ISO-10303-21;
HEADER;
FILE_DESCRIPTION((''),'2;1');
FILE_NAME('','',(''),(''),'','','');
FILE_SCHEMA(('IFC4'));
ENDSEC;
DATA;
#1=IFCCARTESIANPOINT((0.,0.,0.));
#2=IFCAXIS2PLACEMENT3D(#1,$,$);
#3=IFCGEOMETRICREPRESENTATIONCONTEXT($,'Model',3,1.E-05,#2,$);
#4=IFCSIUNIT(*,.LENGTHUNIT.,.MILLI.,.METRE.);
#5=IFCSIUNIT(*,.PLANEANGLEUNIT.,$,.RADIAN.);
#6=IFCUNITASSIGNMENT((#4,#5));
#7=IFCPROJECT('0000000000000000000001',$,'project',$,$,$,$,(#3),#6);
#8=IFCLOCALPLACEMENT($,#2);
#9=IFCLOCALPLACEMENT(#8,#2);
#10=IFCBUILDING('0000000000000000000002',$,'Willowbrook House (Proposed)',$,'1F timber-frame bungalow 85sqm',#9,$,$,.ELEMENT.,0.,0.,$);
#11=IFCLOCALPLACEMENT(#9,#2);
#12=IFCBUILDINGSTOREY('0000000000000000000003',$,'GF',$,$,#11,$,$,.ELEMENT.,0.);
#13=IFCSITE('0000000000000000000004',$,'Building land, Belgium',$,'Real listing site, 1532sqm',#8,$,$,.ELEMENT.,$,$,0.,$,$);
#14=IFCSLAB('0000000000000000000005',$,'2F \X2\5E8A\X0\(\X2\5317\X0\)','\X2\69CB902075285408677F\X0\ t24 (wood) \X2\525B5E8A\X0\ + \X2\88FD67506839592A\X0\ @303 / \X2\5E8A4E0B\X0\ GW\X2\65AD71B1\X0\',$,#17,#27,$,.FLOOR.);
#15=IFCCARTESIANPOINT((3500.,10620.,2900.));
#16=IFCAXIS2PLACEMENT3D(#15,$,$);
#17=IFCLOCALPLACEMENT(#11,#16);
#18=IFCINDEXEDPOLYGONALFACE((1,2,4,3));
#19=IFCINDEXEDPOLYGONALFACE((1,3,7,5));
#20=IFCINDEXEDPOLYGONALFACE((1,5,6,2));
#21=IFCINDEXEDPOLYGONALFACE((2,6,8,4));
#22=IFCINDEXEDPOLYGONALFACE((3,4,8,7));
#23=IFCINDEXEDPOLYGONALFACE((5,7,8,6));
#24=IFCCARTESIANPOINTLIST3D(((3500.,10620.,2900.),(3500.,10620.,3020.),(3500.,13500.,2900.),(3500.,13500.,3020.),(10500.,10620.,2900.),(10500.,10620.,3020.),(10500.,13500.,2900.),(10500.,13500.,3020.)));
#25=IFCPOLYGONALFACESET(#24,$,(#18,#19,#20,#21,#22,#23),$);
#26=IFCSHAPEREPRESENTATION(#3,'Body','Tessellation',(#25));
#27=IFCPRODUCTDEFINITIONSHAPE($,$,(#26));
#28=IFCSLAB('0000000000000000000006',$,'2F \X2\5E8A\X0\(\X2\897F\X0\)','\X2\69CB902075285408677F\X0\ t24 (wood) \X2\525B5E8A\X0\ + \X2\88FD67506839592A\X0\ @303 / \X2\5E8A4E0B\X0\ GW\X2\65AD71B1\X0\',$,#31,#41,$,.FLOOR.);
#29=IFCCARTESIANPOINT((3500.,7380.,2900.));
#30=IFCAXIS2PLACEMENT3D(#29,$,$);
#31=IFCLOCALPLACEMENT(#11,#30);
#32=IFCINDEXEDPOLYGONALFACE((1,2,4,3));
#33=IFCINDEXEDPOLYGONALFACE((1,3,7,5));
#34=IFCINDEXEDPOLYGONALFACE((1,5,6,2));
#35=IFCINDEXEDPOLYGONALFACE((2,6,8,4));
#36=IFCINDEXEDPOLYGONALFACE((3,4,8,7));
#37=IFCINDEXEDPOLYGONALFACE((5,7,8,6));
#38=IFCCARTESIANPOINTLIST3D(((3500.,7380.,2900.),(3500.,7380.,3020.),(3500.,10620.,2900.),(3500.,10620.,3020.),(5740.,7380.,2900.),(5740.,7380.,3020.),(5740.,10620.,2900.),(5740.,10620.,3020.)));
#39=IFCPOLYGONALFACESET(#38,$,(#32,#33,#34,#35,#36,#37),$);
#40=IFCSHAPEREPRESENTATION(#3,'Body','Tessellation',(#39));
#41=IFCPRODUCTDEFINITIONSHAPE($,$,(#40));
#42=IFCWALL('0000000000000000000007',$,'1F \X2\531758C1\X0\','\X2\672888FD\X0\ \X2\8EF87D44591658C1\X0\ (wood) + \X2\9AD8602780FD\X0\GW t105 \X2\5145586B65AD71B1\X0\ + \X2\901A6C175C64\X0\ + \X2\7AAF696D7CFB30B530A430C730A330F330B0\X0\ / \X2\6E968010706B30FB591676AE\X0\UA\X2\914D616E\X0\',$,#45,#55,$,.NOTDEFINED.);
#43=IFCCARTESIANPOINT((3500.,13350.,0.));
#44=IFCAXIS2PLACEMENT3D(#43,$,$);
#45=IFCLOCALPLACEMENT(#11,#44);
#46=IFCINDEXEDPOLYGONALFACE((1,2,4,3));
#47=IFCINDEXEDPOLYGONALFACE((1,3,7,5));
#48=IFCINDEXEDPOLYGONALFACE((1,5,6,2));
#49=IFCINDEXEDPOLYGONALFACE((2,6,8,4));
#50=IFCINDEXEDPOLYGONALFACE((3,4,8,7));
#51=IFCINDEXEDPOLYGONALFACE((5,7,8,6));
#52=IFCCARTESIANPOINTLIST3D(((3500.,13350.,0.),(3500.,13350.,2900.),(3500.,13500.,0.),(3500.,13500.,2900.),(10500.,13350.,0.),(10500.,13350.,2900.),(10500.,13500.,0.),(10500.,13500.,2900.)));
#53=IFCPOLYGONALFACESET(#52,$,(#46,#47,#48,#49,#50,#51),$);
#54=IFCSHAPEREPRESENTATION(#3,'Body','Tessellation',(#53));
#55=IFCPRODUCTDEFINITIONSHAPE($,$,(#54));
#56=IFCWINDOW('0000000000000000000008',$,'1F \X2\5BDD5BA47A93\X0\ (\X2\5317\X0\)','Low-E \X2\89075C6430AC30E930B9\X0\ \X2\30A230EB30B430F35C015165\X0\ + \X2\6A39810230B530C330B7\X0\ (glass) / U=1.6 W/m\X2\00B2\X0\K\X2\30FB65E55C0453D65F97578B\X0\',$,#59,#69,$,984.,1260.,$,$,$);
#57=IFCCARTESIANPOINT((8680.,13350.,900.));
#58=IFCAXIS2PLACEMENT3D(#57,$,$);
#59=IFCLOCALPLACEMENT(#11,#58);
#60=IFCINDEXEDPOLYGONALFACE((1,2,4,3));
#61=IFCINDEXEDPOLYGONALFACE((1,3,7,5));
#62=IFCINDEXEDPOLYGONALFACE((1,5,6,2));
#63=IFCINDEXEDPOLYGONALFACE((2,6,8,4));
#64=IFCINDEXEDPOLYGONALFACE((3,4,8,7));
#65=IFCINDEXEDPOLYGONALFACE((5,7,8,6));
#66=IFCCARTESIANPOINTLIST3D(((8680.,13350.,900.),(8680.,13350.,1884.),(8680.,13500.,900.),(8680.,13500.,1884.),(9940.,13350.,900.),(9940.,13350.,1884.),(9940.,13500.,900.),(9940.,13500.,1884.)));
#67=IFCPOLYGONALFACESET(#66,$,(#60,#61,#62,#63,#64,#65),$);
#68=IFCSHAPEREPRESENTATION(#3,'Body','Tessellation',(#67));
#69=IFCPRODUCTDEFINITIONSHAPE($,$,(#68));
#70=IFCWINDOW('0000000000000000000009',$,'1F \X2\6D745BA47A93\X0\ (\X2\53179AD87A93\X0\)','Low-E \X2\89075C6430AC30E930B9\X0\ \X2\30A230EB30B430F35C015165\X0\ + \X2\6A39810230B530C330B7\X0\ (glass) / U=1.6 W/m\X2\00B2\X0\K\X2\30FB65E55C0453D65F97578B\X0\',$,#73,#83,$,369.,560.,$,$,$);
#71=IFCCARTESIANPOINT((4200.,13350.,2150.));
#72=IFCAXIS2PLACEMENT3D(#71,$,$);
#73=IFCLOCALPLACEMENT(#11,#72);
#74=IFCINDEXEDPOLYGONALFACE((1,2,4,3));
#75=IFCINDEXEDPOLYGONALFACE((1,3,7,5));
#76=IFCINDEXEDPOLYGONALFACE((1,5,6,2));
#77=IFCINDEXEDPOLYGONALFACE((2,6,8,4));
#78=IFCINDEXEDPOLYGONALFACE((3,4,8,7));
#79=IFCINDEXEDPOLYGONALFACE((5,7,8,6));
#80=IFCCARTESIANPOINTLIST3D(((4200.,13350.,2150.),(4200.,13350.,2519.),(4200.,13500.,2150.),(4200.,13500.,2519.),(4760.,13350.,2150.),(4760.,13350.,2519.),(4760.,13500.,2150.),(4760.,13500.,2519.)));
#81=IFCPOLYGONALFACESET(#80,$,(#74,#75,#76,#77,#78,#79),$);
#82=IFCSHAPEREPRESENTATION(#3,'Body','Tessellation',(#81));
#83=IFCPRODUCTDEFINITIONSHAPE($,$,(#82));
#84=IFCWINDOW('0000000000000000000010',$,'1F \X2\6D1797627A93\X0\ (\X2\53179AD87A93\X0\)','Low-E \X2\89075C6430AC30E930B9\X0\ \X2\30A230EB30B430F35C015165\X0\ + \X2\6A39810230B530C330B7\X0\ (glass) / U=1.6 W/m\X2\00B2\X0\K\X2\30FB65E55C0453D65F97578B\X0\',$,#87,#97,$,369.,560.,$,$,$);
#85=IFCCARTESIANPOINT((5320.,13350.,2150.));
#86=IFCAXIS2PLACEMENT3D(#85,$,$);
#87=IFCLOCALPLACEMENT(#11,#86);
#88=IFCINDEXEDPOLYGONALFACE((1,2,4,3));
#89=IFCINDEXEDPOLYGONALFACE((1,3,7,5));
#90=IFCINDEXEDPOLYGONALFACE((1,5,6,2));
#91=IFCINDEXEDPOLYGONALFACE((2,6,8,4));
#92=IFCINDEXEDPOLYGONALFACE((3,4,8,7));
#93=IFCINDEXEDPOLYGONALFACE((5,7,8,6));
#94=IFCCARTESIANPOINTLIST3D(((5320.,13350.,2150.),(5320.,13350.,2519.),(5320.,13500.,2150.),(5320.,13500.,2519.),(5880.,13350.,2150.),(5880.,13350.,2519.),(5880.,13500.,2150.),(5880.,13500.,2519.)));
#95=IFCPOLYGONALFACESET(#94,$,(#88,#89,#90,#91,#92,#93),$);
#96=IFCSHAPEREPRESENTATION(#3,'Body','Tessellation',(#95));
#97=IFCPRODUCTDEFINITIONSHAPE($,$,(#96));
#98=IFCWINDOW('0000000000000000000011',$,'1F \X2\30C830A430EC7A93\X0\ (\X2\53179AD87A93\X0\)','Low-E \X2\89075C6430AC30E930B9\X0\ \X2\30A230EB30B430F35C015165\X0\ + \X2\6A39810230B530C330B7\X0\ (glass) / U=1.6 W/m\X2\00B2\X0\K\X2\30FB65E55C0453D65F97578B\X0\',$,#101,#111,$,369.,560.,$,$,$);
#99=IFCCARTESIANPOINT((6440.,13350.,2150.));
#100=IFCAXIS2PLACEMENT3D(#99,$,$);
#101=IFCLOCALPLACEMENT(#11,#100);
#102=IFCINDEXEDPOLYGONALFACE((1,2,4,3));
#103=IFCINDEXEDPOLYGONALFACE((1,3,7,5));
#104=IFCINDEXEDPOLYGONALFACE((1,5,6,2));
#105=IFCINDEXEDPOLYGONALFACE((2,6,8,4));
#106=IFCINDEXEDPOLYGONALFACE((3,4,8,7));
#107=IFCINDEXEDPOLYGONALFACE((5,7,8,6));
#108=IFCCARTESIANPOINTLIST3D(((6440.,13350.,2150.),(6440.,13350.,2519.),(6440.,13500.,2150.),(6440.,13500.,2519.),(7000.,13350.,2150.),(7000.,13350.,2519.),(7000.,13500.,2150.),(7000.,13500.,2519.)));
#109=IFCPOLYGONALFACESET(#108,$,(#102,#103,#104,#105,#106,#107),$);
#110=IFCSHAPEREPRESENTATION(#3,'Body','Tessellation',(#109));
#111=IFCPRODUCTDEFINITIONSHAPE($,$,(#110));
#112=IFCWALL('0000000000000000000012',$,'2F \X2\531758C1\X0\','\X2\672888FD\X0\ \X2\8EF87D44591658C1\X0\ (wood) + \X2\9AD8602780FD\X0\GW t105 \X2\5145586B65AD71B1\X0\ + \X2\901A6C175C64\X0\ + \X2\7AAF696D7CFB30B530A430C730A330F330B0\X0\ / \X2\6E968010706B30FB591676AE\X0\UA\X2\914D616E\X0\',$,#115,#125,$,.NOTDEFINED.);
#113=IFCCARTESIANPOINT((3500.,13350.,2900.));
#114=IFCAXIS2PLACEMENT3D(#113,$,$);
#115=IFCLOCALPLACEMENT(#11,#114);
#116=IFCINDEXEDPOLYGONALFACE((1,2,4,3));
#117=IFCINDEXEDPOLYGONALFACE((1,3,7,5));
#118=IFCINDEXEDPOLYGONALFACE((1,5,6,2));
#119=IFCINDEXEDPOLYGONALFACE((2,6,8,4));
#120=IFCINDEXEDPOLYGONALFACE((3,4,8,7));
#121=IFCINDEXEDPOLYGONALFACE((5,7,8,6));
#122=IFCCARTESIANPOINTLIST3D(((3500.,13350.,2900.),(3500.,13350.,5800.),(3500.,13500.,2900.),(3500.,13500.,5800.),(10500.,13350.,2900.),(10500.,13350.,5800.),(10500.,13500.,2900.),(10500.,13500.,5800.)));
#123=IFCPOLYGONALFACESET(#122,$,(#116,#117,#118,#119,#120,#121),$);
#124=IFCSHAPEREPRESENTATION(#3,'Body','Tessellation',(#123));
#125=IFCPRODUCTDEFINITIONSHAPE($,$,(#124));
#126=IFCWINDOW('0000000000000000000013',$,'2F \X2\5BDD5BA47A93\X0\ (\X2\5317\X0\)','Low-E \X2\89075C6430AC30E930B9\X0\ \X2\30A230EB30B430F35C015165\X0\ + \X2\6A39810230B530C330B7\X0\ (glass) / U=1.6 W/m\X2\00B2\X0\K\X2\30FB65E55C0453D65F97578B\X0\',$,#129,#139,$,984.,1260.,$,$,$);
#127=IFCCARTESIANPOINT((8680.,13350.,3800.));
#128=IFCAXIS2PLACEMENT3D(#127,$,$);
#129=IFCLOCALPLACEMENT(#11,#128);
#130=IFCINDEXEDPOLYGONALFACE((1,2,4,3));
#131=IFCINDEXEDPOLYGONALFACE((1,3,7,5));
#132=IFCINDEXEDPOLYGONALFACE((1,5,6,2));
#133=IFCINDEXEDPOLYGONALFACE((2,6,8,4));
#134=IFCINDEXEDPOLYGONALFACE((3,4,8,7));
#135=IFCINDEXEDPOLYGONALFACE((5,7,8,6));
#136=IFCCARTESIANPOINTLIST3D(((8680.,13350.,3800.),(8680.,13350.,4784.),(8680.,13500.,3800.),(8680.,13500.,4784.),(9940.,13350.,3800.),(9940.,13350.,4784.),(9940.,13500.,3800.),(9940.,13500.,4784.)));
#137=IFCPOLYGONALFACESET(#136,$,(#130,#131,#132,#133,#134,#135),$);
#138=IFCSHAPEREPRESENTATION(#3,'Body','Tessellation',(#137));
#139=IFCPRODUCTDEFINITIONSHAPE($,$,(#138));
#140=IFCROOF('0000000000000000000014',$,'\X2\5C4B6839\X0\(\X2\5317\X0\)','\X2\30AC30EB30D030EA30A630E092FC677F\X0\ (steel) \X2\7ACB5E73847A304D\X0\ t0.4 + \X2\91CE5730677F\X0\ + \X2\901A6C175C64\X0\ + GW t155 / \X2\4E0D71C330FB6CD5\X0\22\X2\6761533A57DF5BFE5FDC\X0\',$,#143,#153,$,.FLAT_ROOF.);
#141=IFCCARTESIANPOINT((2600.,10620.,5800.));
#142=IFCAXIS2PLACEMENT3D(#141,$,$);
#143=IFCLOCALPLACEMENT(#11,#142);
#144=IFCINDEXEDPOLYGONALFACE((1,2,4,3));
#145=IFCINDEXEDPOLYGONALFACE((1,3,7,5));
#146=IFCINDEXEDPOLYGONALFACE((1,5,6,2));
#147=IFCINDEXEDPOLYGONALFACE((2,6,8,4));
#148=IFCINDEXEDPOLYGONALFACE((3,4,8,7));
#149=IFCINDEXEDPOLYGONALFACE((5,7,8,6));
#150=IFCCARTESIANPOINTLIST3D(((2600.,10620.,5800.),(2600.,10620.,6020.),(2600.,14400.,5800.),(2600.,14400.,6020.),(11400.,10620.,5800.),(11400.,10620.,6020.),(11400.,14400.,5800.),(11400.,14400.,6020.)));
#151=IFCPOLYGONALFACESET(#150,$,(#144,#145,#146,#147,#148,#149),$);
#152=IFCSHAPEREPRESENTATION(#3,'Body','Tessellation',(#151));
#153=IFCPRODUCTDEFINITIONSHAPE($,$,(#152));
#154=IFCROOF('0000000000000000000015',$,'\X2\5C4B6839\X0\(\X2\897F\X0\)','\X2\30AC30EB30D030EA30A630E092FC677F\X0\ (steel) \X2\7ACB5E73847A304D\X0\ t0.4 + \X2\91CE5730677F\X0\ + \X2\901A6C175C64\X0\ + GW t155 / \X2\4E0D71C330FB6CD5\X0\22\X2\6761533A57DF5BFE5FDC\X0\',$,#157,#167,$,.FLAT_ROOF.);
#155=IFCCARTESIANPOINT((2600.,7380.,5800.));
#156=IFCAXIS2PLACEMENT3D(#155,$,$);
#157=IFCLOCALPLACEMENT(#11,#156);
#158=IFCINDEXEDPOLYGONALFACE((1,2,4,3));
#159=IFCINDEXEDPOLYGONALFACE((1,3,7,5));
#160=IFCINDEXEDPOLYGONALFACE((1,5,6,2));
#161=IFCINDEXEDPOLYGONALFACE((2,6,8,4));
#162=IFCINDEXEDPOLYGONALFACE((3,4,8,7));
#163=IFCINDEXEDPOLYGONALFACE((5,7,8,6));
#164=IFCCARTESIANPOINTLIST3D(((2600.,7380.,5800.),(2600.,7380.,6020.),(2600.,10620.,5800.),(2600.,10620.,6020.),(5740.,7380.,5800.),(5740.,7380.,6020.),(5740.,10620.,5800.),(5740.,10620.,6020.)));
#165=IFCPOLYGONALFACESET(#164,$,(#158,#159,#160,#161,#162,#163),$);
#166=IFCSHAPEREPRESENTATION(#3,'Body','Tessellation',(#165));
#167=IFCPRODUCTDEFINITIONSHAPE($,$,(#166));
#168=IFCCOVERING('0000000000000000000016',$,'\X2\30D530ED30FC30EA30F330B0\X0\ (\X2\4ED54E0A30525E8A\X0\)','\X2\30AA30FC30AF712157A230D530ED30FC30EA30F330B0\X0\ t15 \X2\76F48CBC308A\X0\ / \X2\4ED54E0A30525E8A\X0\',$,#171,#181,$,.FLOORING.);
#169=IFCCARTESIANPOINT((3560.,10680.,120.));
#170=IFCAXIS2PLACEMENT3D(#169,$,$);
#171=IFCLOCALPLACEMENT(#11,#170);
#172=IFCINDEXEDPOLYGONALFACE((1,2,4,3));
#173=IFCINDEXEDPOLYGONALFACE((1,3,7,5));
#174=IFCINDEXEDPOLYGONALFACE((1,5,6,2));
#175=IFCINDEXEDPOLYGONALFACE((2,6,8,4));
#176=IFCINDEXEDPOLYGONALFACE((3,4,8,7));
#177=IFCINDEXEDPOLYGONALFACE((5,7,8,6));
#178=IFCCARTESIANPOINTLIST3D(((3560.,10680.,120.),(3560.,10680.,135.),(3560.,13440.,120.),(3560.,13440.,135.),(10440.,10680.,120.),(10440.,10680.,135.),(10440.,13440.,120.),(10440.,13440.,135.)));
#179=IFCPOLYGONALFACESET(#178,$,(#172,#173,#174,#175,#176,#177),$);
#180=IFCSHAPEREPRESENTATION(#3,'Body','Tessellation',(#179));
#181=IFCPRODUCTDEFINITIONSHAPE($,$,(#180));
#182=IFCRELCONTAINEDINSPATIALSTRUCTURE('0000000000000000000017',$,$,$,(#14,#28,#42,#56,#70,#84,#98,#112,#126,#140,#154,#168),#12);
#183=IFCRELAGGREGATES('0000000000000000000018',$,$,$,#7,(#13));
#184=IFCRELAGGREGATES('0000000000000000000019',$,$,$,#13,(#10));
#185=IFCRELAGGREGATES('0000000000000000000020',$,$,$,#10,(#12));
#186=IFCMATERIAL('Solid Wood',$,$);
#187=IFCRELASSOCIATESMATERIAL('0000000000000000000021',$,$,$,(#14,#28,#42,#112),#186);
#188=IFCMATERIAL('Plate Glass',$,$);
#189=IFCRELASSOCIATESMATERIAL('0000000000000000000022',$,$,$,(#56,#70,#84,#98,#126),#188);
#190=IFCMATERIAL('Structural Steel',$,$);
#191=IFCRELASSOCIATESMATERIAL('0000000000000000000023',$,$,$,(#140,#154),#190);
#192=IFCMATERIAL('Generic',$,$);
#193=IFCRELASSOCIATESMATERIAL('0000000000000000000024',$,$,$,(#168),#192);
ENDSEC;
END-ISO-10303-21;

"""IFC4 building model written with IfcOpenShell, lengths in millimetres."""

from ifc_helpers import new_model, si_unit, frame, frame_2d, origin, place, context, project, spatial, rectangle, extrude, material, element, fill, save


model = new_model("IFC4")

# Units and contexts
model_context = context("Model", 3, precision=1e-05, world=origin())
ifc_project = project(units=[si_unit("LENGTHUNIT", "METRE", prefix="MILLI"), si_unit("PLANEANGLEUNIT", "RADIAN")], contexts=[model_context])

# Site, building, storey
site_placement = place(None, origin())
site = spatial("IfcSite", under=ifc_project, at=site_placement, Name="Building land, Belgium", ObjectType="Real listing site, 1532sqm", CompositionType="ELEMENT", RefElevation=0.0)
building_placement = place(site_placement, origin())
building = spatial("IfcBuilding", under=site, at=building_placement, Name="Willowbrook House (Proposed)", ObjectType="1F timber-frame bungalow 85sqm", CompositionType="ELEMENT", ElevationOfRefHeight=0.0, ElevationOfTerrain=0.0)
storey_placement = place(building_placement, origin())
storey = spatial("IfcBuildingStorey", under=building, at=storey_placement, Name="GF", CompositionType="ELEMENT", Elevation=0.0)

# Slabs
ifc_material_1 = material(Name="Solid Wood")
slab_1_placement = place(storey_placement, frame((3500.0, 10620.0, 2900.0)))
element("IfcSlab", 1, at=slab_1_placement, inside=storey, material=ifc_material_1, Name="2F 床(北)", Description="構造用合板 t24 (wood) 剛床 + 製材根太 @303 / 床下 GW断熱", PredefinedType="FLOOR", context=model_context, shape_type="SweptSolid", body=[
    extrude(rectangle(XDim=7000.0, YDim=2880.0, at=frame_2d((3500.0, 1440.0))), frame((3500.0, 10620.0, 2900.0)), (0.0, 0.0, 1.0), 120.0),
])
slab_2_placement = place(storey_placement, frame((3500.0, 7380.0, 2900.0)))
element("IfcSlab", 2, at=slab_2_placement, inside=storey, material=ifc_material_1, Name="2F 床(西)", Description="構造用合板 t24 (wood) 剛床 + 製材根太 @303 / 床下 GW断熱", PredefinedType="FLOOR", context=model_context, shape_type="SweptSolid", body=[
    extrude(rectangle(XDim=2240.0, YDim=3240.0, at=frame_2d((1120.0, 1620.0))), frame((3500.0, 7380.0, 2900.0)), (0.0, 0.0, 1.0), 120.0),
])

# Wall, openings, windows
wall_1_placement = place(storey_placement, frame((3500.0, 13350.0, 0.0)))
wall_1 = element("IfcWall", 3, at=wall_1_placement, inside=storey, material=ifc_material_1, Name="1F 北壁", Description="木製 軸組外壁 (wood) + 高性能GW t105 充填断熱 + 通気層 + 窯業系サイディング / 準耐火・外皮UA配慮", PredefinedType="NOTDEFINED", context=model_context, shape_type="SweptSolid", body=[
    extrude(rectangle(XDim=7000.0, YDim=150.0, at=frame_2d((3500.0, 75.0))), frame((3500.0, 13350.0, 0.0)), (0.0, 0.0, 1.0), 2900.0),
])
opening_1_placement = place(storey_placement, frame((8680.0, 13350.0, 900.0)))
opening_1 = element("IfcOpeningElement", 4, at=opening_1_placement, cuts=wall_1, PredefinedType="NOTDEFINED", context=model_context, shape_type="SweptSolid", body=[
    extrude(rectangle(XDim=1260.0, YDim=150.0, at=frame_2d((630.0, 75.0))), frame((8680.0, 13350.0, 900.0)), (0.0, 0.0, 1.0), 984.0),
])
opening_2_placement = place(storey_placement, frame((4200.0, 13350.0, 2150.0)))
opening_2 = element("IfcOpeningElement", 5, at=opening_2_placement, cuts=wall_1, PredefinedType="NOTDEFINED", context=model_context, shape_type="SweptSolid", body=[
    extrude(rectangle(XDim=560.0, YDim=150.0, at=frame_2d((280.0, 75.0))), frame((4200.0, 13350.0, 2150.0)), (0.0, 0.0, 1.0), 369.0),
])
opening_3_placement = place(storey_placement, frame((5320.0, 13350.0, 2150.0)))
opening_3 = element("IfcOpeningElement", 6, at=opening_3_placement, cuts=wall_1, PredefinedType="NOTDEFINED", context=model_context, shape_type="SweptSolid", body=[
    extrude(rectangle(XDim=560.0, YDim=150.0, at=frame_2d((280.0, 75.0))), frame((5320.0, 13350.0, 2150.0)), (0.0, 0.0, 1.0), 369.0),
])
opening_4_placement = place(storey_placement, frame((6440.0, 13350.0, 2150.0)))
opening_4 = element("IfcOpeningElement", 7, at=opening_4_placement, cuts=wall_1, PredefinedType="NOTDEFINED", context=model_context, shape_type="SweptSolid", body=[
    extrude(rectangle(XDim=560.0, YDim=150.0, at=frame_2d((280.0, 75.0))), frame((6440.0, 13350.0, 2150.0)), (0.0, 0.0, 1.0), 369.0),
])
ifc_material_2 = material(Name="Plate Glass")
window_1_placement = place(storey_placement, frame((8680.0, 13350.0, 900.0)))
window_1 = element("IfcWindow", 8, at=window_1_placement, inside=storey, material=ifc_material_2, Name="1F 寝室窓 (北)", Description="Low-E 複層ガラス アルゴン封入 + 樹脂サッシ (glass) / U=1.6 W/m²K・日射取得型", OverallHeight=984.0, OverallWidth=1260.0, context=model_context, shape_type="SweptSolid", body=[
    extrude(rectangle(XDim=1260.0, YDim=150.0, at=frame_2d((630.0, 75.0))), frame((8680.0, 13350.0, 900.0)), (0.0, 0.0, 1.0), 984.0),
])
fill(opening_1, window_1)
window_2_placement = place(storey_placement, frame((4200.0, 13350.0, 2150.0)))
window_2 = element("IfcWindow", 9, at=window_2_placement, inside=storey, material=ifc_material_2, Name="1F 浴室窓 (北高窓)", Description="Low-E 複層ガラス アルゴン封入 + 樹脂サッシ (glass) / U=1.6 W/m²K・日射取得型", OverallHeight=369.0, OverallWidth=560.0, context=model_context, shape_type="SweptSolid", body=[
    extrude(rectangle(XDim=560.0, YDim=150.0, at=frame_2d((280.0, 75.0))), frame((4200.0, 13350.0, 2150.0)), (0.0, 0.0, 1.0), 369.0),
])
fill(opening_2, window_2)
window_3_placement = place(storey_placement, frame((5320.0, 13350.0, 2150.0)))
window_3 = element("IfcWindow", 10, at=window_3_placement, inside=storey, material=ifc_material_2, Name="1F 洗面窓 (北高窓)", Description="Low-E 複層ガラス アルゴン封入 + 樹脂サッシ (glass) / U=1.6 W/m²K・日射取得型", OverallHeight=369.0, OverallWidth=560.0, context=model_context, shape_type="SweptSolid", body=[
    extrude(rectangle(XDim=560.0, YDim=150.0, at=frame_2d((280.0, 75.0))), frame((5320.0, 13350.0, 2150.0)), (0.0, 0.0, 1.0), 369.0),
])
fill(opening_3, window_3)
window_4_placement = place(storey_placement, frame((6440.0, 13350.0, 2150.0)))
window_4 = element("IfcWindow", 11, at=window_4_placement, inside=storey, material=ifc_material_2, Name="1F トイレ窓 (北高窓)", Description="Low-E 複層ガラス アルゴン封入 + 樹脂サッシ (glass) / U=1.6 W/m²K・日射取得型", OverallHeight=369.0, OverallWidth=560.0, context=model_context, shape_type="SweptSolid", body=[
    extrude(rectangle(XDim=560.0, YDim=150.0, at=frame_2d((280.0, 75.0))), frame((6440.0, 13350.0, 2150.0)), (0.0, 0.0, 1.0), 369.0),
])
fill(opening_4, window_4)

# Wall, opening, window
wall_2_placement = place(storey_placement, frame((3500.0, 13350.0, 2900.0)))
wall_2 = element("IfcWall", 12, at=wall_2_placement, inside=storey, material=ifc_material_1, Name="2F 北壁", Description="木製 軸組外壁 (wood) + 高性能GW t105 充填断熱 + 通気層 + 窯業系サイディング / 準耐火・外皮UA配慮", PredefinedType="NOTDEFINED", context=model_context, shape_type="SweptSolid", body=[
    extrude(rectangle(XDim=7000.0, YDim=150.0, at=frame_2d((3500.0, 75.0))), frame((3500.0, 13350.0, 2900.0)), (0.0, 0.0, 1.0), 2900.0),
])
opening_5_placement = place(storey_placement, frame((8680.0, 13350.0, 3800.0)))
opening_5 = element("IfcOpeningElement", 13, at=opening_5_placement, cuts=wall_2, PredefinedType="NOTDEFINED", context=model_context, shape_type="SweptSolid", body=[
    extrude(rectangle(XDim=1260.0, YDim=150.0, at=frame_2d((630.0, 75.0))), frame((8680.0, 13350.0, 3800.0)), (0.0, 0.0, 1.0), 984.0),
])
window_5_placement = place(storey_placement, frame((8680.0, 13350.0, 3800.0)))
window_5 = element("IfcWindow", 14, at=window_5_placement, inside=storey, material=ifc_material_2, Name="2F 寝室窓 (北)", Description="Low-E 複層ガラス アルゴン封入 + 樹脂サッシ (glass) / U=1.6 W/m²K・日射取得型", OverallHeight=984.0, OverallWidth=1260.0, context=model_context, shape_type="SweptSolid", body=[
    extrude(rectangle(XDim=1260.0, YDim=150.0, at=frame_2d((630.0, 75.0))), frame((8680.0, 13350.0, 3800.0)), (0.0, 0.0, 1.0), 984.0),
])
fill(opening_5, window_5)

# Roofs
ifc_material_3 = material(Name="Structural Steel")
for number, where, name in (
    (15, (2600.0, 10620.0, 5800.0), "屋根(北)"),
):
    element("IfcRoof", number, at=place(storey_placement, frame(where)), inside=storey, material=ifc_material_3, Name=name, Description="ガルバリウム鋼板 (steel) 立平葺き t0.4 + 野地板 + 通気層 + GW t155 / 不燃・法22条区域対応", PredefinedType="FLAT_ROOF", context=model_context, shape_type="SweptSolid", body=[
        extrude(rectangle(XDim=8800.0, YDim=3780.0, at=frame_2d((4400.0, 1890.0))), frame((2600.0, 10620.0, 5800.0)), (0.0, 0.0, 1.0), 220.0),
    ])
roof_placement = place(storey_placement, frame((2600.0, 7380.0, 5800.0)))
element("IfcRoof", 16, at=roof_placement, inside=storey, material=ifc_material_3, Name="屋根(西)", Description="ガルバリウム鋼板 (steel) 立平葺き t0.4 + 野地板 + 通気層 + GW t155 / 不燃・法22条区域対応", PredefinedType="FLAT_ROOF", context=model_context, shape_type="SweptSolid", body=[
    extrude(rectangle(XDim=3140.0, YDim=3240.0, at=frame_2d((1570.0, 1620.0))), frame((2600.0, 7380.0, 5800.0)), (0.0, 0.0, 1.0), 220.0),
])

# Covering
ifc_material_4 = material(Name="Generic")
covering_1_placement = place(storey_placement, frame((3560.0, 10680.0, 120.0)))
element("IfcCovering", 17, at=covering_1_placement, inside=storey, material=ifc_material_4, Name="フローリング (仕上げ床)", Description="オーク無垢フローリング t15 直貼り / 仕上げ床", PredefinedType="FLOORING", context=model_context, shape_type="SweptSolid", body=[
    extrude(rectangle(XDim=6880.0, YDim=2760.0, at=frame_2d((3440.0, 1380.0))), frame((3560.0, 10680.0, 120.0)), (0.0, 0.0, 1.0), 15.0),
])

save(model, "model.ifc")
